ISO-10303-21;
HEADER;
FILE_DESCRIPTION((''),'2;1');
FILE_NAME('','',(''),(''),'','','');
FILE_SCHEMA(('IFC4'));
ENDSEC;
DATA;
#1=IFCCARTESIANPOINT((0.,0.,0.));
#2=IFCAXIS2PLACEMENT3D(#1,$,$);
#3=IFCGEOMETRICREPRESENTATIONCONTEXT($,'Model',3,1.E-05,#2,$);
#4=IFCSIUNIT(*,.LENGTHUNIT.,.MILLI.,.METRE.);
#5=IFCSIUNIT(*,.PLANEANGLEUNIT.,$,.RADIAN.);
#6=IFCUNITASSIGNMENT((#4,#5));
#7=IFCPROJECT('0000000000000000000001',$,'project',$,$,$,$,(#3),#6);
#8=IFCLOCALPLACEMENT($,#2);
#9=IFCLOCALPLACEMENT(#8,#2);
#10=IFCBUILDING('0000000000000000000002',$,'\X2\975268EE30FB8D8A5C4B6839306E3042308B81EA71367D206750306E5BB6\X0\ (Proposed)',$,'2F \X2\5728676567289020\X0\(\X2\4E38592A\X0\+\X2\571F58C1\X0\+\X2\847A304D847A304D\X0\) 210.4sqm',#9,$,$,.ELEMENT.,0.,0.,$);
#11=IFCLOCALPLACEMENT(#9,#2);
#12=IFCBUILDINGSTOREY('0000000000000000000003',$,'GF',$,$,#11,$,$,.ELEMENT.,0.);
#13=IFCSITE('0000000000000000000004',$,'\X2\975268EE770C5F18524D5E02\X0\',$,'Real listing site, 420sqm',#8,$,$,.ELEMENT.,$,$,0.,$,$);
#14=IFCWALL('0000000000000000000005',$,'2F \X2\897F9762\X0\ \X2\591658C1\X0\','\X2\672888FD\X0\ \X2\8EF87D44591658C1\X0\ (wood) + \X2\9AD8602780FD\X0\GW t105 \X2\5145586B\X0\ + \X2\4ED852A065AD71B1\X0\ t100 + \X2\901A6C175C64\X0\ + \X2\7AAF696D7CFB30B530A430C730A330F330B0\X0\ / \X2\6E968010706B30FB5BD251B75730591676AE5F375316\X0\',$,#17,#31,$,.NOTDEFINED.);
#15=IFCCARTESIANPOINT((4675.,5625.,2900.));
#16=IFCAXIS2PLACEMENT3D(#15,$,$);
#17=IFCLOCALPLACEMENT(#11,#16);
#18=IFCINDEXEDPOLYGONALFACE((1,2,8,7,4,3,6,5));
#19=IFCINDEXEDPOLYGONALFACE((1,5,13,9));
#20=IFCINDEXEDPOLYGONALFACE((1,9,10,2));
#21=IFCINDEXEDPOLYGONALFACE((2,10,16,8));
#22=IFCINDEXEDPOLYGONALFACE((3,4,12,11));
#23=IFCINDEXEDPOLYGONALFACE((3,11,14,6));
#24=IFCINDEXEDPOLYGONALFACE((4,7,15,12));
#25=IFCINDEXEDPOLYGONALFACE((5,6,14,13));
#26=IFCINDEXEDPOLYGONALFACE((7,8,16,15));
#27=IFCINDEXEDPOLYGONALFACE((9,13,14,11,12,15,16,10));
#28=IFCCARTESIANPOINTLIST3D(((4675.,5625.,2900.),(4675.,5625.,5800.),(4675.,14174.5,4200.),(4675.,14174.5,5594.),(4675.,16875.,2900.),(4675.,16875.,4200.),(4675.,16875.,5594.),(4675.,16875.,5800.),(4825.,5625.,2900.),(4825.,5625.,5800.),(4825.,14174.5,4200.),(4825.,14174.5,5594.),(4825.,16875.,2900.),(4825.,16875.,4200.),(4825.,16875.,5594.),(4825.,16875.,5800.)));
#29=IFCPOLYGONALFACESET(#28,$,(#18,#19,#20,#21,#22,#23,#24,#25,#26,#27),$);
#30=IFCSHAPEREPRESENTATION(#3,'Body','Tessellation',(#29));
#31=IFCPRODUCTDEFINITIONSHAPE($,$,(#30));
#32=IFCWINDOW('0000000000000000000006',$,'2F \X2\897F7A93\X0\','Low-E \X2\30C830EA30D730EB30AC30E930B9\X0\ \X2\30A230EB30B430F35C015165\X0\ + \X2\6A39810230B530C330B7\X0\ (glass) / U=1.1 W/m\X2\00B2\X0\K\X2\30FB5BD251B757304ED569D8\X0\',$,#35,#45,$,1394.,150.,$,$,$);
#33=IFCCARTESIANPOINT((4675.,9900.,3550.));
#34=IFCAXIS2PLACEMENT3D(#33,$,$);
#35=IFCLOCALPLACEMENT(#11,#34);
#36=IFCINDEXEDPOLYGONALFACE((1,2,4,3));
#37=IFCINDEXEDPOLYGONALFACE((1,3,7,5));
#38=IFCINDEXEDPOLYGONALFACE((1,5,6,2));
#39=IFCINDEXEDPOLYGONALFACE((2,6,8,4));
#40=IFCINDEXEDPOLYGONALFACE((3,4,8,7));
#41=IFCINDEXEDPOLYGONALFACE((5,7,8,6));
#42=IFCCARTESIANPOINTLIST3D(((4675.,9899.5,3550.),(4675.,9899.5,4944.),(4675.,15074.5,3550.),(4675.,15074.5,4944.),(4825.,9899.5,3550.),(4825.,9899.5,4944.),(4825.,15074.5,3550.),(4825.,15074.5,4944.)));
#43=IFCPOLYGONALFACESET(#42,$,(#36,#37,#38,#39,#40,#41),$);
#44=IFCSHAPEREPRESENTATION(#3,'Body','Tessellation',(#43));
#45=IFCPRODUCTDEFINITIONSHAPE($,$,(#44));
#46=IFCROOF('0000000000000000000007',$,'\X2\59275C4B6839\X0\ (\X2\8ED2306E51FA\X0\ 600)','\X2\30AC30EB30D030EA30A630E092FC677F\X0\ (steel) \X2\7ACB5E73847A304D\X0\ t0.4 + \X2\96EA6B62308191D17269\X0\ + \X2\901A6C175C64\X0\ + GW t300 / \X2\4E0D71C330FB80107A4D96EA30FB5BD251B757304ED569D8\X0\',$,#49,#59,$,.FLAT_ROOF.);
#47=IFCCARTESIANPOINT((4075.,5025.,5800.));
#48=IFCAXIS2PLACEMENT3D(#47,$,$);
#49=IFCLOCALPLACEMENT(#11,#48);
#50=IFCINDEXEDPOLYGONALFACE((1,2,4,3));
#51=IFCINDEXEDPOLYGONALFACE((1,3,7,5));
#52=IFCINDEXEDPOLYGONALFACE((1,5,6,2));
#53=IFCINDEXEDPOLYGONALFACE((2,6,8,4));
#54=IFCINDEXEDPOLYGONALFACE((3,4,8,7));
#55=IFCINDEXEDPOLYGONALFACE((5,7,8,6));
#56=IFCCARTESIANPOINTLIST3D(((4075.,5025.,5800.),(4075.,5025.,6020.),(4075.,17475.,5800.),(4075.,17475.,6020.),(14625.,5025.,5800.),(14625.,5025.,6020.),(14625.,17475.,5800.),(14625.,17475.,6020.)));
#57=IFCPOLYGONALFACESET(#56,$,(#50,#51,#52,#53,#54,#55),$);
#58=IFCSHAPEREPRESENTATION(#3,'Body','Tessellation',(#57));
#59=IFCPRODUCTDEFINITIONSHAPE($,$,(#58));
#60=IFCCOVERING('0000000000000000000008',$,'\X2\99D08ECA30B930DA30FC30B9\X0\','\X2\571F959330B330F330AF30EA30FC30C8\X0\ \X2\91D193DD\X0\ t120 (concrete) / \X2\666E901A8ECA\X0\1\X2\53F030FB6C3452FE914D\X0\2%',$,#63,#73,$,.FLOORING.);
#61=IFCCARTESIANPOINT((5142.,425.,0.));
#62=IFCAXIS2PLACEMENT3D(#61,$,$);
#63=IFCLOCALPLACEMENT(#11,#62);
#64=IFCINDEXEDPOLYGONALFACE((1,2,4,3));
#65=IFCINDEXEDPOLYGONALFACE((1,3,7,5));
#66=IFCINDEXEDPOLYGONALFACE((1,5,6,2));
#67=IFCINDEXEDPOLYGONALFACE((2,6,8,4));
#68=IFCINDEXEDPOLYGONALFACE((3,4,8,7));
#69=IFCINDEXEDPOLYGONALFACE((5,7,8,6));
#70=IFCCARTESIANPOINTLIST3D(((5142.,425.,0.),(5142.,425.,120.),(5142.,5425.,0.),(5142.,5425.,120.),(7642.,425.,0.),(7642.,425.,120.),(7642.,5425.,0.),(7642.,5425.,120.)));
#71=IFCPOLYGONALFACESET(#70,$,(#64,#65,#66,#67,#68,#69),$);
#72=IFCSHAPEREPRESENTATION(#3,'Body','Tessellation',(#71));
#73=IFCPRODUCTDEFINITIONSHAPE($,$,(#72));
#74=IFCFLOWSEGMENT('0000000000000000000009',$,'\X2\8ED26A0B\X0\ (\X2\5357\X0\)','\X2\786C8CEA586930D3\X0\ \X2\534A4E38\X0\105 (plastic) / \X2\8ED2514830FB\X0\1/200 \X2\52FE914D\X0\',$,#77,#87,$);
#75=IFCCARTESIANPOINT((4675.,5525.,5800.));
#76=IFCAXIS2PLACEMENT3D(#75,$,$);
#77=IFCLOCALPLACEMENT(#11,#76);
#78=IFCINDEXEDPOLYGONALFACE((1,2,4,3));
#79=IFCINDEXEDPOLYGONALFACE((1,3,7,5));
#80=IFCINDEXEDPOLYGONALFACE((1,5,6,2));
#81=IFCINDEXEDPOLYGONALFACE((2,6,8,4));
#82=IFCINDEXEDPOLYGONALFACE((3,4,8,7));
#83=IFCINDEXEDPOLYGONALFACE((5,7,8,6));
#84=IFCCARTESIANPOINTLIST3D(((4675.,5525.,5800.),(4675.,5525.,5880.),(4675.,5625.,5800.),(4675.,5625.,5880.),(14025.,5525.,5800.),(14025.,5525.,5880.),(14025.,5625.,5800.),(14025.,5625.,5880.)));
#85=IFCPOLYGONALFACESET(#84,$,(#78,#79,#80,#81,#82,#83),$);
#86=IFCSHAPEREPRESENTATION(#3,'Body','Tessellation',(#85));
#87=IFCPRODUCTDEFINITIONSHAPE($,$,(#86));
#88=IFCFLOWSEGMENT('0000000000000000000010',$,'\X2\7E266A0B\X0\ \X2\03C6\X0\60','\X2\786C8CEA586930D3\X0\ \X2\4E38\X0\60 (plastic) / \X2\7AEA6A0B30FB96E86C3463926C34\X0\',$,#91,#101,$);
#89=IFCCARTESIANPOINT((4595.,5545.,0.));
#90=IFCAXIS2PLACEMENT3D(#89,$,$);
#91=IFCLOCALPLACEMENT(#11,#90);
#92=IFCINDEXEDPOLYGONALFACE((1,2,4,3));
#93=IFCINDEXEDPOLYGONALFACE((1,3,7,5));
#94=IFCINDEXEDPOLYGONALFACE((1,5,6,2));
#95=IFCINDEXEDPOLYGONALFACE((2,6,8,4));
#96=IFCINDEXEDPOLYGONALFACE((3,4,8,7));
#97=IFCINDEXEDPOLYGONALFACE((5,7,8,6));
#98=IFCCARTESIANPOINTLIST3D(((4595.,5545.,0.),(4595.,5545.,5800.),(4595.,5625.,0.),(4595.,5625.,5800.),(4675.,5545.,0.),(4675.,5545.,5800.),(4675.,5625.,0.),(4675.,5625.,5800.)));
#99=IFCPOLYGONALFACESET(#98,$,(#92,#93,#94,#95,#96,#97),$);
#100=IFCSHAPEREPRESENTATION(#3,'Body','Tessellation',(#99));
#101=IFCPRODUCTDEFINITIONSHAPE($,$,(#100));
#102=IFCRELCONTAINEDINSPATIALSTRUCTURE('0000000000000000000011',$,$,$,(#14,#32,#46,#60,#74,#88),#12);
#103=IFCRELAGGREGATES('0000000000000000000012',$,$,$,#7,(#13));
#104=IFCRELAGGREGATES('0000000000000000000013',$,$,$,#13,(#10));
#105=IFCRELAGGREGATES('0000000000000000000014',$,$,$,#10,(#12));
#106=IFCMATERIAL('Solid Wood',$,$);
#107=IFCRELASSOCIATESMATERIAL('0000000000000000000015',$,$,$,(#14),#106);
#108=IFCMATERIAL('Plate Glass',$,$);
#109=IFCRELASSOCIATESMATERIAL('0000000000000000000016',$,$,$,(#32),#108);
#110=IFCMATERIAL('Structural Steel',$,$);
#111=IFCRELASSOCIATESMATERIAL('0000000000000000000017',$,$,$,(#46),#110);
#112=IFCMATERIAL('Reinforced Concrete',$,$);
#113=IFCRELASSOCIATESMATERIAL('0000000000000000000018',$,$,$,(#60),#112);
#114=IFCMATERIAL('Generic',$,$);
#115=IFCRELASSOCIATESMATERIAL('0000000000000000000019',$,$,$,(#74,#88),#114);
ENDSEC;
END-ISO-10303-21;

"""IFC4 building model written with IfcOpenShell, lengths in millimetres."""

from ifc_helpers import new_model, si_unit, frame, frame_2d, origin, place, context, project, spatial, rectangle, extrude, material, element, fill, save


model = new_model("IFC4")

# Units and contexts
model_context = context("Model", 3, precision=1e-05, world=origin())
ifc_project = project(units=[si_unit("LENGTHUNIT", "METRE", prefix="MILLI"), si_unit("PLANEANGLEUNIT", "RADIAN")], contexts=[model_context])

# Site, building, storey
site_placement = place(None, origin())
site = spatial("IfcSite", under=ifc_project, at=site_placement, Name="青森県弘前市", ObjectType="Real listing site, 420sqm", CompositionType="ELEMENT", RefElevation=0.0)
building_placement = place(site_placement, origin())
building = spatial("IfcBuilding", under=site, at=building_placement, Name="青森・越屋根のある自然素材の家 (Proposed)", ObjectType="2F 在来木造(丸太+土壁+葺き葺き) 210.4sqm", CompositionType="ELEMENT", ElevationOfRefHeight=0.0, ElevationOfTerrain=0.0)
storey_placement = place(building_placement, origin())
storey = spatial("IfcBuildingStorey", under=building, at=storey_placement, Name="GF", CompositionType="ELEMENT", Elevation=0.0)

# Shared definitions
ifc_material_1 = material(Name="Solid Wood")

# Shared definitions
ifc_material_2 = material(Name="Reinforced Concrete")

# Shared definitions
ifc_material_3 = material(Name="Plate Glass")

# Wall, opening, window
wall_1_placement = place(storey_placement, frame((4675.0, 5625.0, 2900.0)))
wall_1 = element("IfcWall", 1, at=wall_1_placement, inside=storey, material=ifc_material_1, Name="2F 西面 外壁", Description="木製 軸組外壁 (wood) + 高性能GW t105 充填 + 付加断熱 t100 + 通気層 + 窯業系サイディング / 準耐火・寒冷地外皮強化", PredefinedType="NOTDEFINED", context=model_context, shape_type="SweptSolid", body=[
    extrude(rectangle(XDim=150.0, YDim=11250.0, at=frame_2d((75.0, 5625.0))), frame((4675.0, 5625.0, 2900.0)), (0.0, 0.0, 1.0), 2900.0),
])
opening_1_placement = place(storey_placement, frame((4675.0, 9900.0, 3550.0)))
opening_1 = element("IfcOpeningElement", 2, at=opening_1_placement, cuts=wall_1, PredefinedType="NOTDEFINED", context=model_context, shape_type="SweptSolid", body=[
    extrude(rectangle(XDim=150.0, YDim=5175.0, at=frame_2d((75.0, 2587.0))), frame((4675.0, 9900.0, 3550.0)), (0.0, 0.0, 1.0), 1394.0),
])
window_1_placement = place(storey_placement, frame((4675.0, 9900.0, 3550.0)))
window_1 = element("IfcWindow", 3, at=window_1_placement, inside=storey, material=ifc_material_3, Name="2F 西窓", Description="Low-E トリプルガラス アルゴン封入 + 樹脂サッシ (glass) / U=1.1 W/m²K・寒冷地仕様", OverallHeight=1394.0, OverallWidth=150.0, context=model_context, shape_type="SweptSolid", body=[
    extrude(rectangle(XDim=150.0, YDim=5175.0, at=frame_2d((75.0, 2587.0))), frame((4675.0, 9900.0, 3550.0)), (0.0, 0.0, 1.0), 1394.0),
])
fill(opening_1, window_1)

# Roof
ifc_material_4 = material(Name="Structural Steel")
roof_placement = place(storey_placement, frame((4075.0, 5025.0, 5800.0)))
element("IfcRoof", 4, at=roof_placement, inside=storey, material=ifc_material_4, Name="大屋根 (軒の出 600)", Description="ガルバリウム鋼板 (steel) 立平葺き t0.4 + 雪止め金物 + 通気層 + GW t300 / 不燃・耐積雪・寒冷地仕様", PredefinedType="FLAT_ROOF", context=model_context, shape_type="SweptSolid", body=[
    extrude(rectangle(XDim=10550.0, YDim=12450.0, at=frame_2d((5275.0, 6225.0))), frame((4075.0, 5025.0, 5800.0)), (0.0, 0.0, 1.0), 220.0),
])

# Covering
covering_placement = place(storey_placement, frame((5142.0, 425.0, 0.0)))
element("IfcCovering", 5, at=covering_placement, inside=storey, material=ifc_material_2, Name="駐車スペース", Description="土間コンクリート 金鏝 t120 (concrete) / 普通車1台・水勾配2%", PredefinedType="FLOORING", context=model_context, shape_type="SweptSolid", body=[
    extrude(rectangle(XDim=2500.0, YDim=5000.0, at=frame_2d((1250.0, 2500.0))), frame((5142.0, 425.0, 0.0)), (0.0, 0.0, 1.0), 120.0),
])

# Flow segments
ifc_material_5 = material(Name="Generic")
flow_segment_1_placement = place(storey_placement, frame((4675.0, 5525.0, 5800.0)))
element("IfcFlowSegment", 6, at=flow_segment_1_placement, inside=storey, material=ifc_material_5, Name="軒樋 (南)", Description="硬質塩ビ 半丸105 (plastic) / 軒先・1/200 勾配", context=model_context, shape_type="SweptSolid", body=[
    extrude(rectangle(XDim=9350.0, YDim=100.0, at=frame_2d((4675.0, 50.0))), frame((4675.0, 5525.0, 5800.0)), (0.0, 0.0, 1.0), 80.0),
])
flow_segment_2_placement = place(storey_placement, frame((4595.0, 5545.0, 0.0)))
element("IfcFlowSegment", 7, at=flow_segment_2_placement, inside=storey, material=ifc_material_5, Name="縦樋 φ60", Description="硬質塩ビ 丸60 (plastic) / 竪樋・雨水排水", context=model_context, shape_type="SweptSolid", body=[
    extrude(rectangle(XDim=80.0, YDim=80.0, at=frame_2d((40.0, 40.0))), frame((4595.0, 5545.0, 0.0)), (0.0, 0.0, 1.0), 5800.0),
])

save(model, "model.ifc")
